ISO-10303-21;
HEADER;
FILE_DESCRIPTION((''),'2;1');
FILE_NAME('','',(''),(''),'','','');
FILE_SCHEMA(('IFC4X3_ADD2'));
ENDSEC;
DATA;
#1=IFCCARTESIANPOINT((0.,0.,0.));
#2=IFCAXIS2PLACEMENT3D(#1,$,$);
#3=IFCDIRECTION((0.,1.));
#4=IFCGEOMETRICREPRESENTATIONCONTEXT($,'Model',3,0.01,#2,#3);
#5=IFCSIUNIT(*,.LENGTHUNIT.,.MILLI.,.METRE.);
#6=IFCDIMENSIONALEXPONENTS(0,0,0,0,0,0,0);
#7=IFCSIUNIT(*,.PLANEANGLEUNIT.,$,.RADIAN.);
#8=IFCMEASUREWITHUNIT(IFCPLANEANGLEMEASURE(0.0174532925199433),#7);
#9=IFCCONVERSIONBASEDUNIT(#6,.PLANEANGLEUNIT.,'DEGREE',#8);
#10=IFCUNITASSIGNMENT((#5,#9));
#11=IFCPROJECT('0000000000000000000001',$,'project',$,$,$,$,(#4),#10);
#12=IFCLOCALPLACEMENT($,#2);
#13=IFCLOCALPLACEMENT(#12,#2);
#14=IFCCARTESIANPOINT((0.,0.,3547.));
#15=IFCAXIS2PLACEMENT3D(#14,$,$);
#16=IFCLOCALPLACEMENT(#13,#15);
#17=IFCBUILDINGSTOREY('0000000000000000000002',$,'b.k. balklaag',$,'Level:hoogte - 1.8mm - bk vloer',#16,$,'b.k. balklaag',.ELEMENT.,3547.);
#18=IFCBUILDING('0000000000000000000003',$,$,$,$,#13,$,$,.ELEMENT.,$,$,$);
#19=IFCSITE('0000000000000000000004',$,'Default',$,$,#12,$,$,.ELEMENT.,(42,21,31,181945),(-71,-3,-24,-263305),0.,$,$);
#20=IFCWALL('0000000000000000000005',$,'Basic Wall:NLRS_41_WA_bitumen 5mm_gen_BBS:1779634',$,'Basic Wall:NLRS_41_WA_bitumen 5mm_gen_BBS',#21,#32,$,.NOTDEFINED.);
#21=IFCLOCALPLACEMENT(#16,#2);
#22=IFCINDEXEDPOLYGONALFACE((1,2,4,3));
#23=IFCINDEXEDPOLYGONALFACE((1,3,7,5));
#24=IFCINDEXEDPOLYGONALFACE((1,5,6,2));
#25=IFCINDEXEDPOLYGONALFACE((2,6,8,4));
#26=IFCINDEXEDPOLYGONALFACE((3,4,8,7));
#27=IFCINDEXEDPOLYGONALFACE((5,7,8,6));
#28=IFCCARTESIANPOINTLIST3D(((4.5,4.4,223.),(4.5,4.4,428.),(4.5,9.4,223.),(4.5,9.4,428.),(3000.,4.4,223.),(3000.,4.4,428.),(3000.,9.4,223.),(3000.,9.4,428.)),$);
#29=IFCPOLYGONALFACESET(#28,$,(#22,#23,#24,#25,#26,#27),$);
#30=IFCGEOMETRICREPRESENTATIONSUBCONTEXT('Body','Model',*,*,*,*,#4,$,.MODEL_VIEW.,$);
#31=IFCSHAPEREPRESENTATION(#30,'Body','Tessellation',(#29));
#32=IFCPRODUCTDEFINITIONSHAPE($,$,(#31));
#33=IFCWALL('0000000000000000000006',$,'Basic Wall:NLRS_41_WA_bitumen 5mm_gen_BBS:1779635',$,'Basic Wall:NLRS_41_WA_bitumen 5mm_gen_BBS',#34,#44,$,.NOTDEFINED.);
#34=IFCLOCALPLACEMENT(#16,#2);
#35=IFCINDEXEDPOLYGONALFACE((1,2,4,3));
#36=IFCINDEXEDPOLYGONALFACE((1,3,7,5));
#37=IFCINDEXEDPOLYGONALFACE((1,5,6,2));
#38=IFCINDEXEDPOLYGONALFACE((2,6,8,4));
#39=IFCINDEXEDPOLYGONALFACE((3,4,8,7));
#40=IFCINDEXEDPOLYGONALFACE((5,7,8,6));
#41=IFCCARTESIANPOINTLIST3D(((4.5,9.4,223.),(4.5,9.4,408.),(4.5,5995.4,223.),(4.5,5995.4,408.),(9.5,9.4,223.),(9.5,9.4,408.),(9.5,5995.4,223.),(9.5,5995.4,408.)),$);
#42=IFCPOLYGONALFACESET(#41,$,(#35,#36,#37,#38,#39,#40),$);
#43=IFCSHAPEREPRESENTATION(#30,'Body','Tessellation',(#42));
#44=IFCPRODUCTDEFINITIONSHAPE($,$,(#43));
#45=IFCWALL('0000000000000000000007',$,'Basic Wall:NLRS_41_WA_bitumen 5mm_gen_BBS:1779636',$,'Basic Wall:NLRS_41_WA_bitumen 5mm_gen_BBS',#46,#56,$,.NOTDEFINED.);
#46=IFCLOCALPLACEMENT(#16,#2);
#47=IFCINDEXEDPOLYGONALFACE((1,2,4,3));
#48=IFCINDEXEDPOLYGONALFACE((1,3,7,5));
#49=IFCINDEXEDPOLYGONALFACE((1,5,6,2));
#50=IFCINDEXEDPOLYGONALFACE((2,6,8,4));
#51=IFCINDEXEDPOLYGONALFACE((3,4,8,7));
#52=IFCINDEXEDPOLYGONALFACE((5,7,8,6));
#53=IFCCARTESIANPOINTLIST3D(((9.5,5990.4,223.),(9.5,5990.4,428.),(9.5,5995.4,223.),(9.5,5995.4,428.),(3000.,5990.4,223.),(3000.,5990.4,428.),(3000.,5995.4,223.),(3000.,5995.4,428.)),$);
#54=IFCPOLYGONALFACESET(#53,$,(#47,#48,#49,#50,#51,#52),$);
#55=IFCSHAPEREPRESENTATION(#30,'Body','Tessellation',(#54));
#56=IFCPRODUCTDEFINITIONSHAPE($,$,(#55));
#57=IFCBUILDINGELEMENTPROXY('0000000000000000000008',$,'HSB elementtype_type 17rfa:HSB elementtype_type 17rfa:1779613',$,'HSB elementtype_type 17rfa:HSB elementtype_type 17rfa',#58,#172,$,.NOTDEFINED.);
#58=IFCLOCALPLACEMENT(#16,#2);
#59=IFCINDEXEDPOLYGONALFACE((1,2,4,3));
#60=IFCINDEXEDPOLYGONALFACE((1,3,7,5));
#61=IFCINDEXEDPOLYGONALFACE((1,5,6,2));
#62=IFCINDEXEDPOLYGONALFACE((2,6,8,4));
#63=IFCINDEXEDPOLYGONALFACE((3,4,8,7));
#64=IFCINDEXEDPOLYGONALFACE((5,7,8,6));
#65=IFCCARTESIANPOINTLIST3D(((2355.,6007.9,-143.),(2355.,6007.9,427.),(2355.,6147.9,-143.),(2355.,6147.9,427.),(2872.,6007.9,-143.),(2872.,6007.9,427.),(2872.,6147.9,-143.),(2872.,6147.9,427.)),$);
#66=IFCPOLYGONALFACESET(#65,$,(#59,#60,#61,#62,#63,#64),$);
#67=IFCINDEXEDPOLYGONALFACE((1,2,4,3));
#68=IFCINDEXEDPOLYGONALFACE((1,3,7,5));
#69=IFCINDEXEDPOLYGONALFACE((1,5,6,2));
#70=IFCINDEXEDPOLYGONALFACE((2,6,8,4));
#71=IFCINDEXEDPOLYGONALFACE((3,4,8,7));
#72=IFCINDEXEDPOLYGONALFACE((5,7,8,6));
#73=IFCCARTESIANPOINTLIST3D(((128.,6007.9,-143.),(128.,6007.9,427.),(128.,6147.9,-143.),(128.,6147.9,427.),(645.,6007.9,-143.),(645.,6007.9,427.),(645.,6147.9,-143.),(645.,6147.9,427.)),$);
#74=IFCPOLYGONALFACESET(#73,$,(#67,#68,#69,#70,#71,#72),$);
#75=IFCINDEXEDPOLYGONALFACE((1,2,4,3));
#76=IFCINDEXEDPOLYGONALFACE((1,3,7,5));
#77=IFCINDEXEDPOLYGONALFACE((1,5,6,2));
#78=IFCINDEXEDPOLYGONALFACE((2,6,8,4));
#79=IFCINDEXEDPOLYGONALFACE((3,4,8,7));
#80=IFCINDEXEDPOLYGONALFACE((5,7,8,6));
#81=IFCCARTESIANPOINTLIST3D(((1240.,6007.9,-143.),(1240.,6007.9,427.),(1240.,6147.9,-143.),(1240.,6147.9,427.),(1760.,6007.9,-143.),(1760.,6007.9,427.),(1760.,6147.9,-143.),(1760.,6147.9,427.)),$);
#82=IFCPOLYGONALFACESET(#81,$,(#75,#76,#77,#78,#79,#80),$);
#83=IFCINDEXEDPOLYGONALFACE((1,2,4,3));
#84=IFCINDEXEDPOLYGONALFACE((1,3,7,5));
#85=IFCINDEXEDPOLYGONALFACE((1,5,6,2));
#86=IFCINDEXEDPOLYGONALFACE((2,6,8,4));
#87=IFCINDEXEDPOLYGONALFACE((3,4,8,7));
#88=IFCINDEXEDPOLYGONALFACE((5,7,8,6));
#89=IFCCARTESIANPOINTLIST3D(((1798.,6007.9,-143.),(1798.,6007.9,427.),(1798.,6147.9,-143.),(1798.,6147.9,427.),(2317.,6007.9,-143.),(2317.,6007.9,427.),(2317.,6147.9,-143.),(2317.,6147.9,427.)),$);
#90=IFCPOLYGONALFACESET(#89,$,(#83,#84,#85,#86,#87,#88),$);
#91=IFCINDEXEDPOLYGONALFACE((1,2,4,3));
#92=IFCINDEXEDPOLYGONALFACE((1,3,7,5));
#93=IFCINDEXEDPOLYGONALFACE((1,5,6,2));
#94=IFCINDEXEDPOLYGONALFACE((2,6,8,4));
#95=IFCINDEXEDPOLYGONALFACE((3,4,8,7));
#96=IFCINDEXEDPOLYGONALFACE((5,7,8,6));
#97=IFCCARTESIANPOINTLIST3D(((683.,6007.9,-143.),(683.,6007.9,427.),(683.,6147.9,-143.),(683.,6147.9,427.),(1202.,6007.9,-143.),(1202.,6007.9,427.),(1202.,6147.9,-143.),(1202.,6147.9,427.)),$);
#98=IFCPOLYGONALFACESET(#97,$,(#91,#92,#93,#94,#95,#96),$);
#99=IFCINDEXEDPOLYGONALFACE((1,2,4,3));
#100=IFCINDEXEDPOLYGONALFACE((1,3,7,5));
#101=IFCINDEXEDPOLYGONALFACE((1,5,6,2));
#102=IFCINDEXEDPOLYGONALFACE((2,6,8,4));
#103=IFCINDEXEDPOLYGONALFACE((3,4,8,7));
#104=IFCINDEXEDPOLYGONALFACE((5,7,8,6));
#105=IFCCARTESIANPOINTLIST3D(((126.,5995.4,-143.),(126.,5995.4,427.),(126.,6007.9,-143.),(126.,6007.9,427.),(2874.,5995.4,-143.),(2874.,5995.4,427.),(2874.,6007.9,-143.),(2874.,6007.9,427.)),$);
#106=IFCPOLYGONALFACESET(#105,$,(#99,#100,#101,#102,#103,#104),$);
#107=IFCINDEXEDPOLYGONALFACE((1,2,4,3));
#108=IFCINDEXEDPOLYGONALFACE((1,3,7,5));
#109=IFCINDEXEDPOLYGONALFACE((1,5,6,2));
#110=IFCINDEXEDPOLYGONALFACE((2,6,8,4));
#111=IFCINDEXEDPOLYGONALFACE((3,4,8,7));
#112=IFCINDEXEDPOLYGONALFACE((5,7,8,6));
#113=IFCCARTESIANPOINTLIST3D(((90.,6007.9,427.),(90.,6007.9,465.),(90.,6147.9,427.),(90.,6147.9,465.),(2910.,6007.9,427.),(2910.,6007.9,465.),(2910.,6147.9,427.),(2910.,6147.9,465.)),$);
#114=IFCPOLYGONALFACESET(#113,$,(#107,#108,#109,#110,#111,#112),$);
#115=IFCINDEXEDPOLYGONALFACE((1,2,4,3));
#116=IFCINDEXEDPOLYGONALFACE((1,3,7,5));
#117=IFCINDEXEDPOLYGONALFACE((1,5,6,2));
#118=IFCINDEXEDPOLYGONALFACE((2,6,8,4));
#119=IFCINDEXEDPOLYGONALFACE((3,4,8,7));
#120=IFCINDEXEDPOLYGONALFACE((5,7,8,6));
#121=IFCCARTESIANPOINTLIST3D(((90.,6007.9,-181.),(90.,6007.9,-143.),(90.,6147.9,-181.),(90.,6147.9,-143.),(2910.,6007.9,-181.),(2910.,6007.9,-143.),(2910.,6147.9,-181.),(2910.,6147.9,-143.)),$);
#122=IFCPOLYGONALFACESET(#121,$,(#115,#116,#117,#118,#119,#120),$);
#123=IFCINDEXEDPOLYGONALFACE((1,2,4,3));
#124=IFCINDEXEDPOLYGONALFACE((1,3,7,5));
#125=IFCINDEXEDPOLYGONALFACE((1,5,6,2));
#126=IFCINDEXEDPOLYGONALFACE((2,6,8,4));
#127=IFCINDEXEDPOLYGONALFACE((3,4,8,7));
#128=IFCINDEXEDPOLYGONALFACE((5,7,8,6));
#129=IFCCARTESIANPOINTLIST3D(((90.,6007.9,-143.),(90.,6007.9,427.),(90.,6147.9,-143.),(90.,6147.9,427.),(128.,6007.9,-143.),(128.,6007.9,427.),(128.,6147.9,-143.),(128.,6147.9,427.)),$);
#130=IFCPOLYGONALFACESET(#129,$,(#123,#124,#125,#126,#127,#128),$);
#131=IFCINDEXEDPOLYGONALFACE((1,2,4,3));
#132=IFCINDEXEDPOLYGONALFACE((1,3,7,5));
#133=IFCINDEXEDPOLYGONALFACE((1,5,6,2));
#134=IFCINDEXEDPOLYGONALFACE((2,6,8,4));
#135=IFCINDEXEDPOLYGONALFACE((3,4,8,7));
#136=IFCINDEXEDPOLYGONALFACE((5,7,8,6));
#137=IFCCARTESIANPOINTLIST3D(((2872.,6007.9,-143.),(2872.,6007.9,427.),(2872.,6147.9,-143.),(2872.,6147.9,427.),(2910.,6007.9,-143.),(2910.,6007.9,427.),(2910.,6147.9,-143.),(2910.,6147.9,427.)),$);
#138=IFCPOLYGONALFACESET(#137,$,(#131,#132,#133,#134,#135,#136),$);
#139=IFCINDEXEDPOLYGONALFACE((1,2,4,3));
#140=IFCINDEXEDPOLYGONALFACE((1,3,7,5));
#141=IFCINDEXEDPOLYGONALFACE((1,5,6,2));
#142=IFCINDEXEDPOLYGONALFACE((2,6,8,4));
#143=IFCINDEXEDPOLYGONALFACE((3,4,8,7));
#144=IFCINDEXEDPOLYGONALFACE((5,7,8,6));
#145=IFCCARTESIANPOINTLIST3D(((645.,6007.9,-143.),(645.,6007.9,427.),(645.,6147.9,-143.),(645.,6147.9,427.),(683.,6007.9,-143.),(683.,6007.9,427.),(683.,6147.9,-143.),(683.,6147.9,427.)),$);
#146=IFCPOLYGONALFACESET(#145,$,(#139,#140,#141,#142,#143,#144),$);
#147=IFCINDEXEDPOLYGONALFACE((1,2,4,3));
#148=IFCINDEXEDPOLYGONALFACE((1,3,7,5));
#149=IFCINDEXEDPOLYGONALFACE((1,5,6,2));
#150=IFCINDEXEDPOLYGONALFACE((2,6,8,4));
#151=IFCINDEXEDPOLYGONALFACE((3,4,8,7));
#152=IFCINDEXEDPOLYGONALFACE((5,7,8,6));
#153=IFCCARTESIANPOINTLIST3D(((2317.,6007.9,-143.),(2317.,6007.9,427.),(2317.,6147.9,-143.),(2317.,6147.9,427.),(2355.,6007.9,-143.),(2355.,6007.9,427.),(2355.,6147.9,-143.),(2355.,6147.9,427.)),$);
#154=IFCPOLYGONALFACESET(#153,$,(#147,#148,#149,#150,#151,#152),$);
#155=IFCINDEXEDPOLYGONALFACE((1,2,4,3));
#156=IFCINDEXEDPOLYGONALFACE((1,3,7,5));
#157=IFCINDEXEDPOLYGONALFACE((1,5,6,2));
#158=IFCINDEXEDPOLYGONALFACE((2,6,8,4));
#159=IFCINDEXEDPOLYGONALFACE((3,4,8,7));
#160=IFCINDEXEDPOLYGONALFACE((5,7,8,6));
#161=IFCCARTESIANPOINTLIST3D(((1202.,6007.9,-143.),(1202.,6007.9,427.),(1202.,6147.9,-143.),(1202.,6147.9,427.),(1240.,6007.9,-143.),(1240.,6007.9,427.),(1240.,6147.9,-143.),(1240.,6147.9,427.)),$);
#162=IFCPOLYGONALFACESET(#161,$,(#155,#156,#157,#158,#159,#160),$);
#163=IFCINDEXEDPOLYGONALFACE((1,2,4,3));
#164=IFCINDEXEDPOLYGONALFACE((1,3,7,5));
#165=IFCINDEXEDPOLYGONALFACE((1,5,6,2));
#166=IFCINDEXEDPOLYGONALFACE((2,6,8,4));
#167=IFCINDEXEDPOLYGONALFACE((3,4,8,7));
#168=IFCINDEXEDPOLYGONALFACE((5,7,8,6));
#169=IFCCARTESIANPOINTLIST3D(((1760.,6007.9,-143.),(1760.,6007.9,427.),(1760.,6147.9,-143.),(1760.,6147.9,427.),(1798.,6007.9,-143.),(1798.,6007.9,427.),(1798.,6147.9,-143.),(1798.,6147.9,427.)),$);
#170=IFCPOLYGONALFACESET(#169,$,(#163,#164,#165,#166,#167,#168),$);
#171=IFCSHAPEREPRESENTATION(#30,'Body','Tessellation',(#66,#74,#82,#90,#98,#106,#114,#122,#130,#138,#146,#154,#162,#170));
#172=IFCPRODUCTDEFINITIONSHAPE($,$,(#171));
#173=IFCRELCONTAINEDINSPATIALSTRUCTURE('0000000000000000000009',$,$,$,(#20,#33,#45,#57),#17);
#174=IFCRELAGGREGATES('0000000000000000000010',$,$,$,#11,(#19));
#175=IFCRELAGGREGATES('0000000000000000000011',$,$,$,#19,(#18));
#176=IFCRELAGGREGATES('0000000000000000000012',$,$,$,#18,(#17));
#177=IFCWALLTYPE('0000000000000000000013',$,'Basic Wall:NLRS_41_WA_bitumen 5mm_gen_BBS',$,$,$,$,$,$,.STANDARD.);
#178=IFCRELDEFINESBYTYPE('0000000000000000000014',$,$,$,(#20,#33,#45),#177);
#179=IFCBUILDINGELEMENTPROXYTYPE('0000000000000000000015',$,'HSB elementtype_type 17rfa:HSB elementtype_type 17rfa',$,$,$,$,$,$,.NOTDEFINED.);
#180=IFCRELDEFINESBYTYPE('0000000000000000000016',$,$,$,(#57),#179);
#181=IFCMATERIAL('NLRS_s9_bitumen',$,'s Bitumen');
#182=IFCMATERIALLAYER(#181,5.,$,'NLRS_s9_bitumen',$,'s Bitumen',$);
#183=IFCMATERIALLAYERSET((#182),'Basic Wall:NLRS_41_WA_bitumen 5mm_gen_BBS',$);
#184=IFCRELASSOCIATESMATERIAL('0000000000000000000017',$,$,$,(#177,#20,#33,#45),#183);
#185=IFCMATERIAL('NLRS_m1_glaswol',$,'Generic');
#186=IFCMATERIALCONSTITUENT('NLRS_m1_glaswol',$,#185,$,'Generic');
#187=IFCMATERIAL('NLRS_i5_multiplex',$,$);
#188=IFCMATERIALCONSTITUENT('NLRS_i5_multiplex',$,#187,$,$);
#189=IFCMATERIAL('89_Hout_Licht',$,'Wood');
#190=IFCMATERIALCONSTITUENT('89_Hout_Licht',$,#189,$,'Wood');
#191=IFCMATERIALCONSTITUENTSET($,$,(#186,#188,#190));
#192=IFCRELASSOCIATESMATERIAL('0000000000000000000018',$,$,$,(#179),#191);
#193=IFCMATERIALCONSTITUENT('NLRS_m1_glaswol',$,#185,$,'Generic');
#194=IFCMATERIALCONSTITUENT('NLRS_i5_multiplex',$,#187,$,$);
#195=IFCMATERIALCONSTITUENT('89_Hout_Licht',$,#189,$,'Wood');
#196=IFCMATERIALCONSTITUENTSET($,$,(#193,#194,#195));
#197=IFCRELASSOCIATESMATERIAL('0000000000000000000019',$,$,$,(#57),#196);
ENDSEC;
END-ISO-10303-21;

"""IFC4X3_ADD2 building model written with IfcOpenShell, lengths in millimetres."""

from ifc_helpers import new_model, entity, si_unit, converted_unit, direction, frame, frame_2d, origin, origin_2d_with_axis, place, context, subcontext, project, spatial, rectangle, extrude, source, transform, mapped, material, layer, layer_set, layer_usage, constituent, constituent_set, type_object, type_shapes, element, save


model = new_model("IFC4X3_ADD2")

# Units and contexts
model_context = context("Model", 3, precision=0.01, world=origin(), true_north=direction((0.0, 1.0)))
body_context = subcontext(model_context, "Body", "Model", "MODEL_VIEW")
ifc_project = project(units=[si_unit("LENGTHUNIT", "METRE", prefix="MILLI"), converted_unit("PLANEANGLEUNIT", "DEGREE", entity("IfcPlaneAngleMeasure", 0.0174532925199433), si_unit("PLANEANGLEUNIT", "RADIAN"), dimensions=[0, 0, 0, 0, 0, 0, 0])], contexts=[model_context])

# Site, building, storey
site_placement = place(None, origin())
site = spatial("IfcSite", under=ifc_project, at=site_placement, Name="Default", CompositionType="ELEMENT", RefLatitude=(42, 21, 31, 181945), RefLongitude=(-71, -3, -24, -263305), RefElevation=0.0)
building_placement = place(site_placement, origin())
building = spatial("IfcBuilding", under=site, at=building_placement, CompositionType="ELEMENT")
storey_placement = place(building_placement, frame((0.0, 0.0, 3547.0)))
storey = spatial("IfcBuildingStorey", under=building, at=storey_placement, Name="b.k. balklaag", ObjectType="Level:hoogte - 1.8mm - bk vloer", LongName="b.k. balklaag", CompositionType="ELEMENT", Elevation=3547.0)

# Shared definitions
ifc_material_1 = material(Name="89_Hout_Licht", Category="Wood")

# Walls
ifc_material_2 = material(Name="NLRS_s9_bitumen", Category="s Bitumen")
ifc_layer = layer(ifc_material_2, 5.0, Name="NLRS_s9_bitumen", Category="s Bitumen")
ifc_layer_set = layer_set([ifc_layer], Name="Basic Wall:NLRS_41_WA_bitumen 5mm_gen_BBS")
ifc_layer_usage_1 = layer_usage(ifc_layer_set, "AXIS2", "NEGATIVE", 2.5)
wall_type = type_object("IfcWallType", Name="Basic Wall:NLRS_41_WA_bitumen 5mm_gen_BBS", PredefinedType="STANDARD", material=ifc_layer_set)
wall_1_placement = place(storey_placement, frame((3000.0, 6.9, 223.0), z_axis=(0.0, 0.0, 1.0), x_axis=(-1.0, 0.0, 0.0)))
element("IfcWall", 1, at=wall_1_placement, inside=storey, type_object=wall_type, material=ifc_layer_usage_1, Name="Basic Wall:NLRS_41_WA_bitumen 5mm_gen_BBS:1779634", ObjectType="Basic Wall:NLRS_41_WA_bitumen 5mm_gen_BBS", PredefinedType="NOTDEFINED", context=body_context, shape_type="SweptSolid", body=[
    extrude(rectangle(XDim=2995.5, YDim=5.0, at=frame_2d((1497.8, 0.0), x_axis=(-1.0, 0.0))), origin(), (0.0, 0.0, 1.0), 205.0),
])
ifc_layer_usage_2 = layer_usage(ifc_layer_set, "AXIS2", "NEGATIVE", 2.5)
wall_2_placement = place(storey_placement, frame((7.0, 9.4, 223.0), z_axis=(0.0, 0.0, 1.0), x_axis=(0.0, 1.0, 0.0)))
element("IfcWall", 2, at=wall_2_placement, inside=storey, type_object=wall_type, material=ifc_layer_usage_2, Name="Basic Wall:NLRS_41_WA_bitumen 5mm_gen_BBS:1779635", ObjectType="Basic Wall:NLRS_41_WA_bitumen 5mm_gen_BBS", PredefinedType="NOTDEFINED", context=body_context, shape_type="SweptSolid", body=[
    extrude(rectangle(XDim=5986.0, YDim=5.0, at=frame_2d((2993.0, 0.0), x_axis=(-1.0, 0.0))), origin(), (0.0, 0.0, 1.0), 185.0),
])
ifc_layer_usage_3 = layer_usage(ifc_layer_set, "AXIS2", "NEGATIVE", 2.5)
wall_3_placement = place(storey_placement, frame((9.5, 5992.9, 223.0)))
element("IfcWall", 3, at=wall_3_placement, inside=storey, type_object=wall_type, material=ifc_layer_usage_3, Name="Basic Wall:NLRS_41_WA_bitumen 5mm_gen_BBS:1779636", ObjectType="Basic Wall:NLRS_41_WA_bitumen 5mm_gen_BBS", PredefinedType="NOTDEFINED", context=body_context, shape_type="SweptSolid", body=[
    extrude(rectangle(XDim=2990.5, YDim=5.0, at=frame_2d((1495.3, 0.0), x_axis=(-1.0, 0.0))), origin(), (0.0, 0.0, 1.0), 205.0),
])

# Building element proxy
ifc_material_3 = material(Name="NLRS_m1_glaswol", Category="Generic")
ifc_constituent_1 = constituent(ifc_material_3, Name="NLRS_m1_glaswol", Category="Generic")
ifc_material_4 = material(Name="NLRS_i5_multiplex")
ifc_constituent_2 = constituent(ifc_material_4, Name="NLRS_i5_multiplex")
ifc_constituent_3 = constituent(ifc_material_1, Name="89_Hout_Licht", Category="Wood")
ifc_constituent_set_1 = constituent_set(constituents=[ifc_constituent_1, ifc_constituent_2, ifc_constituent_3])
ifc_constituent_4 = constituent(ifc_material_3, Name="NLRS_m1_glaswol", Category="Generic")
ifc_constituent_5 = constituent(ifc_material_4, Name="NLRS_i5_multiplex")
ifc_constituent_6 = constituent(ifc_material_1, Name="89_Hout_Licht", Category="Wood")
ifc_constituent_set_2 = constituent_set(constituents=[ifc_constituent_4, ifc_constituent_5, ifc_constituent_6])
building_element_proxy_type_1 = type_object("IfcBuildingElementProxyType", Name="HSB elementtype_type 17rfa:HSB elementtype_type 17rfa", PredefinedType="NOTDEFINED", material=ifc_constituent_set_2)
shared_shape_1 = source(origin(), body_context, "Body", "SweptSolid", [
    extrude(rectangle(XDim=140.0, YDim=517.0, at=frame_2d((0.0, 0.0), x_axis=(1.0, 0.0))), frame((-1149.5, -70.0, 38.0), z_axis=(0.0, 0.0, 1.0), x_axis=(0.0, 1.0, 0.0)), (0.0, 0.0, 1.0), 570.0),
    extrude(rectangle(XDim=140.0, YDim=517.0, at=frame_2d((0.0, 0.0), x_axis=(1.0, 0.0))), frame((1077.5, -70.0, 38.0), z_axis=(0.0, 0.0, 1.0), x_axis=(0.0, 1.0, 0.0)), (0.0, 0.0, 1.0), 570.0),
    extrude(rectangle(XDim=140.0, YDim=520.0, at=origin_2d_with_axis()), frame((-36.0, -70.0, 38.0), z_axis=(0.0, 0.0, 1.0), x_axis=(0.0, 1.0, 0.0)), (0.0, 0.0, 1.0), 570.0),
    extrude(rectangle(XDim=140.0, YDim=519.0, at=origin_2d_with_axis()), frame((-593.5, -70.0, 38.0), z_axis=(0.0, 0.0, 1.0), x_axis=(0.0, 1.0, 0.0)), (0.0, 0.0, 1.0), 570.0),
    extrude(rectangle(XDim=140.0, YDim=519.0, at=origin_2d_with_axis()), frame((521.5, -70.0, 38.0), z_axis=(0.0, 0.0, 1.0), x_axis=(0.0, 1.0, 0.0)), (0.0, 0.0, 1.0), 570.0),
    extrude(rectangle(XDim=12.5, YDim=2748.0, at=frame_2d((0.0, 0.0), x_axis=(1.0, 0.0))), frame((-36.0, 6.2, 38.0), z_axis=(0.0, 0.0, 1.0), x_axis=(0.0, 1.0, 0.0)), (0.0, 0.0, 1.0), 570.0),
    extrude(rectangle(XDim=140.0, YDim=2820.0, at=origin_2d_with_axis()), frame((-36.0, -70.0, 608.0), z_axis=(0.0, 0.0, 1.0), x_axis=(0.0, 1.0, 0.0)), (0.0, 0.0, 1.0), 38.0),
    extrude(rectangle(XDim=140.0, YDim=2820.0, at=origin_2d_with_axis()), frame((-36.0, -70.0, 0.0), z_axis=(0.0, 0.0, 1.0), x_axis=(0.0, 1.0, 0.0)), (0.0, 0.0, 1.0), 38.0),
    extrude(rectangle(XDim=140.0, YDim=38.0, at=frame_2d((0.0, 0.0), x_axis=(1.0, 0.0))), frame((1355.0, -70.0, 38.0), z_axis=(0.0, 0.0, 1.0), x_axis=(0.0, 1.0, 0.0)), (0.0, 0.0, 1.0), 570.0),
    extrude(rectangle(XDim=140.0, YDim=38.0, at=frame_2d((0.0, 0.0), x_axis=(1.0, 0.0))), frame((-1427.0, -70.0, 38.0), z_axis=(0.0, 0.0, 1.0), x_axis=(0.0, 1.0, 0.0)), (0.0, 0.0, 1.0), 570.0),
    extrude(rectangle(XDim=140.0, YDim=38.0, at=origin_2d_with_axis()), frame((800.0, -70.0, 38.0), z_axis=(0.0, 0.0, 1.0), x_axis=(0.0, 1.0, 0.0)), (0.0, 0.0, 1.0), 570.0),
    extrude(rectangle(XDim=140.0, YDim=38.0, at=frame_2d((0.0, 0.0), x_axis=(1.0, 0.0))), frame((-872.0, -70.0, 38.0), z_axis=(0.0, 0.0, 1.0), x_axis=(0.0, 1.0, 0.0)), (0.0, 0.0, 1.0), 570.0),
    extrude(rectangle(XDim=140.0, YDim=38.0, at=frame_2d((0.0, 0.0), x_axis=(1.0, 0.0))), frame((243.0, -70.0, 38.0), z_axis=(0.0, 0.0, 1.0), x_axis=(0.0, 1.0, 0.0)), (0.0, 0.0, 1.0), 570.0),
    extrude(rectangle(XDim=140.0, YDim=38.0, at=frame_2d((0.0, 0.0), x_axis=(1.0, 0.0))), frame((-315.0, -70.0, 38.0), z_axis=(0.0, 0.0, 1.0), x_axis=(0.0, 1.0, 0.0)), (0.0, 0.0, 1.0), 570.0),
])
type_shapes(building_element_proxy_type_1, [shared_shape_1])
proxy_1_placement = place(storey_placement, frame((1464.0, 6007.9, -181.0), z_axis=(0.0, 0.0, 1.0), x_axis=(-1.0, 0.0, 0.0)))
element("IfcBuildingElementProxy", 4, at=proxy_1_placement, inside=storey, type_object=building_element_proxy_type_1, material=ifc_constituent_set_1, Name="HSB elementtype_type 17rfa:HSB elementtype_type 17rfa:1779613", ObjectType="HSB elementtype_type 17rfa:HSB elementtype_type 17rfa", PredefinedType="NOTDEFINED", context=body_context, shape_type="MappedRepresentation", body=[
    mapped(shared_shape_1, transform((0.0, 0.0, 0.0), scale=1.0)),
])

save(model, "model.ifc")
